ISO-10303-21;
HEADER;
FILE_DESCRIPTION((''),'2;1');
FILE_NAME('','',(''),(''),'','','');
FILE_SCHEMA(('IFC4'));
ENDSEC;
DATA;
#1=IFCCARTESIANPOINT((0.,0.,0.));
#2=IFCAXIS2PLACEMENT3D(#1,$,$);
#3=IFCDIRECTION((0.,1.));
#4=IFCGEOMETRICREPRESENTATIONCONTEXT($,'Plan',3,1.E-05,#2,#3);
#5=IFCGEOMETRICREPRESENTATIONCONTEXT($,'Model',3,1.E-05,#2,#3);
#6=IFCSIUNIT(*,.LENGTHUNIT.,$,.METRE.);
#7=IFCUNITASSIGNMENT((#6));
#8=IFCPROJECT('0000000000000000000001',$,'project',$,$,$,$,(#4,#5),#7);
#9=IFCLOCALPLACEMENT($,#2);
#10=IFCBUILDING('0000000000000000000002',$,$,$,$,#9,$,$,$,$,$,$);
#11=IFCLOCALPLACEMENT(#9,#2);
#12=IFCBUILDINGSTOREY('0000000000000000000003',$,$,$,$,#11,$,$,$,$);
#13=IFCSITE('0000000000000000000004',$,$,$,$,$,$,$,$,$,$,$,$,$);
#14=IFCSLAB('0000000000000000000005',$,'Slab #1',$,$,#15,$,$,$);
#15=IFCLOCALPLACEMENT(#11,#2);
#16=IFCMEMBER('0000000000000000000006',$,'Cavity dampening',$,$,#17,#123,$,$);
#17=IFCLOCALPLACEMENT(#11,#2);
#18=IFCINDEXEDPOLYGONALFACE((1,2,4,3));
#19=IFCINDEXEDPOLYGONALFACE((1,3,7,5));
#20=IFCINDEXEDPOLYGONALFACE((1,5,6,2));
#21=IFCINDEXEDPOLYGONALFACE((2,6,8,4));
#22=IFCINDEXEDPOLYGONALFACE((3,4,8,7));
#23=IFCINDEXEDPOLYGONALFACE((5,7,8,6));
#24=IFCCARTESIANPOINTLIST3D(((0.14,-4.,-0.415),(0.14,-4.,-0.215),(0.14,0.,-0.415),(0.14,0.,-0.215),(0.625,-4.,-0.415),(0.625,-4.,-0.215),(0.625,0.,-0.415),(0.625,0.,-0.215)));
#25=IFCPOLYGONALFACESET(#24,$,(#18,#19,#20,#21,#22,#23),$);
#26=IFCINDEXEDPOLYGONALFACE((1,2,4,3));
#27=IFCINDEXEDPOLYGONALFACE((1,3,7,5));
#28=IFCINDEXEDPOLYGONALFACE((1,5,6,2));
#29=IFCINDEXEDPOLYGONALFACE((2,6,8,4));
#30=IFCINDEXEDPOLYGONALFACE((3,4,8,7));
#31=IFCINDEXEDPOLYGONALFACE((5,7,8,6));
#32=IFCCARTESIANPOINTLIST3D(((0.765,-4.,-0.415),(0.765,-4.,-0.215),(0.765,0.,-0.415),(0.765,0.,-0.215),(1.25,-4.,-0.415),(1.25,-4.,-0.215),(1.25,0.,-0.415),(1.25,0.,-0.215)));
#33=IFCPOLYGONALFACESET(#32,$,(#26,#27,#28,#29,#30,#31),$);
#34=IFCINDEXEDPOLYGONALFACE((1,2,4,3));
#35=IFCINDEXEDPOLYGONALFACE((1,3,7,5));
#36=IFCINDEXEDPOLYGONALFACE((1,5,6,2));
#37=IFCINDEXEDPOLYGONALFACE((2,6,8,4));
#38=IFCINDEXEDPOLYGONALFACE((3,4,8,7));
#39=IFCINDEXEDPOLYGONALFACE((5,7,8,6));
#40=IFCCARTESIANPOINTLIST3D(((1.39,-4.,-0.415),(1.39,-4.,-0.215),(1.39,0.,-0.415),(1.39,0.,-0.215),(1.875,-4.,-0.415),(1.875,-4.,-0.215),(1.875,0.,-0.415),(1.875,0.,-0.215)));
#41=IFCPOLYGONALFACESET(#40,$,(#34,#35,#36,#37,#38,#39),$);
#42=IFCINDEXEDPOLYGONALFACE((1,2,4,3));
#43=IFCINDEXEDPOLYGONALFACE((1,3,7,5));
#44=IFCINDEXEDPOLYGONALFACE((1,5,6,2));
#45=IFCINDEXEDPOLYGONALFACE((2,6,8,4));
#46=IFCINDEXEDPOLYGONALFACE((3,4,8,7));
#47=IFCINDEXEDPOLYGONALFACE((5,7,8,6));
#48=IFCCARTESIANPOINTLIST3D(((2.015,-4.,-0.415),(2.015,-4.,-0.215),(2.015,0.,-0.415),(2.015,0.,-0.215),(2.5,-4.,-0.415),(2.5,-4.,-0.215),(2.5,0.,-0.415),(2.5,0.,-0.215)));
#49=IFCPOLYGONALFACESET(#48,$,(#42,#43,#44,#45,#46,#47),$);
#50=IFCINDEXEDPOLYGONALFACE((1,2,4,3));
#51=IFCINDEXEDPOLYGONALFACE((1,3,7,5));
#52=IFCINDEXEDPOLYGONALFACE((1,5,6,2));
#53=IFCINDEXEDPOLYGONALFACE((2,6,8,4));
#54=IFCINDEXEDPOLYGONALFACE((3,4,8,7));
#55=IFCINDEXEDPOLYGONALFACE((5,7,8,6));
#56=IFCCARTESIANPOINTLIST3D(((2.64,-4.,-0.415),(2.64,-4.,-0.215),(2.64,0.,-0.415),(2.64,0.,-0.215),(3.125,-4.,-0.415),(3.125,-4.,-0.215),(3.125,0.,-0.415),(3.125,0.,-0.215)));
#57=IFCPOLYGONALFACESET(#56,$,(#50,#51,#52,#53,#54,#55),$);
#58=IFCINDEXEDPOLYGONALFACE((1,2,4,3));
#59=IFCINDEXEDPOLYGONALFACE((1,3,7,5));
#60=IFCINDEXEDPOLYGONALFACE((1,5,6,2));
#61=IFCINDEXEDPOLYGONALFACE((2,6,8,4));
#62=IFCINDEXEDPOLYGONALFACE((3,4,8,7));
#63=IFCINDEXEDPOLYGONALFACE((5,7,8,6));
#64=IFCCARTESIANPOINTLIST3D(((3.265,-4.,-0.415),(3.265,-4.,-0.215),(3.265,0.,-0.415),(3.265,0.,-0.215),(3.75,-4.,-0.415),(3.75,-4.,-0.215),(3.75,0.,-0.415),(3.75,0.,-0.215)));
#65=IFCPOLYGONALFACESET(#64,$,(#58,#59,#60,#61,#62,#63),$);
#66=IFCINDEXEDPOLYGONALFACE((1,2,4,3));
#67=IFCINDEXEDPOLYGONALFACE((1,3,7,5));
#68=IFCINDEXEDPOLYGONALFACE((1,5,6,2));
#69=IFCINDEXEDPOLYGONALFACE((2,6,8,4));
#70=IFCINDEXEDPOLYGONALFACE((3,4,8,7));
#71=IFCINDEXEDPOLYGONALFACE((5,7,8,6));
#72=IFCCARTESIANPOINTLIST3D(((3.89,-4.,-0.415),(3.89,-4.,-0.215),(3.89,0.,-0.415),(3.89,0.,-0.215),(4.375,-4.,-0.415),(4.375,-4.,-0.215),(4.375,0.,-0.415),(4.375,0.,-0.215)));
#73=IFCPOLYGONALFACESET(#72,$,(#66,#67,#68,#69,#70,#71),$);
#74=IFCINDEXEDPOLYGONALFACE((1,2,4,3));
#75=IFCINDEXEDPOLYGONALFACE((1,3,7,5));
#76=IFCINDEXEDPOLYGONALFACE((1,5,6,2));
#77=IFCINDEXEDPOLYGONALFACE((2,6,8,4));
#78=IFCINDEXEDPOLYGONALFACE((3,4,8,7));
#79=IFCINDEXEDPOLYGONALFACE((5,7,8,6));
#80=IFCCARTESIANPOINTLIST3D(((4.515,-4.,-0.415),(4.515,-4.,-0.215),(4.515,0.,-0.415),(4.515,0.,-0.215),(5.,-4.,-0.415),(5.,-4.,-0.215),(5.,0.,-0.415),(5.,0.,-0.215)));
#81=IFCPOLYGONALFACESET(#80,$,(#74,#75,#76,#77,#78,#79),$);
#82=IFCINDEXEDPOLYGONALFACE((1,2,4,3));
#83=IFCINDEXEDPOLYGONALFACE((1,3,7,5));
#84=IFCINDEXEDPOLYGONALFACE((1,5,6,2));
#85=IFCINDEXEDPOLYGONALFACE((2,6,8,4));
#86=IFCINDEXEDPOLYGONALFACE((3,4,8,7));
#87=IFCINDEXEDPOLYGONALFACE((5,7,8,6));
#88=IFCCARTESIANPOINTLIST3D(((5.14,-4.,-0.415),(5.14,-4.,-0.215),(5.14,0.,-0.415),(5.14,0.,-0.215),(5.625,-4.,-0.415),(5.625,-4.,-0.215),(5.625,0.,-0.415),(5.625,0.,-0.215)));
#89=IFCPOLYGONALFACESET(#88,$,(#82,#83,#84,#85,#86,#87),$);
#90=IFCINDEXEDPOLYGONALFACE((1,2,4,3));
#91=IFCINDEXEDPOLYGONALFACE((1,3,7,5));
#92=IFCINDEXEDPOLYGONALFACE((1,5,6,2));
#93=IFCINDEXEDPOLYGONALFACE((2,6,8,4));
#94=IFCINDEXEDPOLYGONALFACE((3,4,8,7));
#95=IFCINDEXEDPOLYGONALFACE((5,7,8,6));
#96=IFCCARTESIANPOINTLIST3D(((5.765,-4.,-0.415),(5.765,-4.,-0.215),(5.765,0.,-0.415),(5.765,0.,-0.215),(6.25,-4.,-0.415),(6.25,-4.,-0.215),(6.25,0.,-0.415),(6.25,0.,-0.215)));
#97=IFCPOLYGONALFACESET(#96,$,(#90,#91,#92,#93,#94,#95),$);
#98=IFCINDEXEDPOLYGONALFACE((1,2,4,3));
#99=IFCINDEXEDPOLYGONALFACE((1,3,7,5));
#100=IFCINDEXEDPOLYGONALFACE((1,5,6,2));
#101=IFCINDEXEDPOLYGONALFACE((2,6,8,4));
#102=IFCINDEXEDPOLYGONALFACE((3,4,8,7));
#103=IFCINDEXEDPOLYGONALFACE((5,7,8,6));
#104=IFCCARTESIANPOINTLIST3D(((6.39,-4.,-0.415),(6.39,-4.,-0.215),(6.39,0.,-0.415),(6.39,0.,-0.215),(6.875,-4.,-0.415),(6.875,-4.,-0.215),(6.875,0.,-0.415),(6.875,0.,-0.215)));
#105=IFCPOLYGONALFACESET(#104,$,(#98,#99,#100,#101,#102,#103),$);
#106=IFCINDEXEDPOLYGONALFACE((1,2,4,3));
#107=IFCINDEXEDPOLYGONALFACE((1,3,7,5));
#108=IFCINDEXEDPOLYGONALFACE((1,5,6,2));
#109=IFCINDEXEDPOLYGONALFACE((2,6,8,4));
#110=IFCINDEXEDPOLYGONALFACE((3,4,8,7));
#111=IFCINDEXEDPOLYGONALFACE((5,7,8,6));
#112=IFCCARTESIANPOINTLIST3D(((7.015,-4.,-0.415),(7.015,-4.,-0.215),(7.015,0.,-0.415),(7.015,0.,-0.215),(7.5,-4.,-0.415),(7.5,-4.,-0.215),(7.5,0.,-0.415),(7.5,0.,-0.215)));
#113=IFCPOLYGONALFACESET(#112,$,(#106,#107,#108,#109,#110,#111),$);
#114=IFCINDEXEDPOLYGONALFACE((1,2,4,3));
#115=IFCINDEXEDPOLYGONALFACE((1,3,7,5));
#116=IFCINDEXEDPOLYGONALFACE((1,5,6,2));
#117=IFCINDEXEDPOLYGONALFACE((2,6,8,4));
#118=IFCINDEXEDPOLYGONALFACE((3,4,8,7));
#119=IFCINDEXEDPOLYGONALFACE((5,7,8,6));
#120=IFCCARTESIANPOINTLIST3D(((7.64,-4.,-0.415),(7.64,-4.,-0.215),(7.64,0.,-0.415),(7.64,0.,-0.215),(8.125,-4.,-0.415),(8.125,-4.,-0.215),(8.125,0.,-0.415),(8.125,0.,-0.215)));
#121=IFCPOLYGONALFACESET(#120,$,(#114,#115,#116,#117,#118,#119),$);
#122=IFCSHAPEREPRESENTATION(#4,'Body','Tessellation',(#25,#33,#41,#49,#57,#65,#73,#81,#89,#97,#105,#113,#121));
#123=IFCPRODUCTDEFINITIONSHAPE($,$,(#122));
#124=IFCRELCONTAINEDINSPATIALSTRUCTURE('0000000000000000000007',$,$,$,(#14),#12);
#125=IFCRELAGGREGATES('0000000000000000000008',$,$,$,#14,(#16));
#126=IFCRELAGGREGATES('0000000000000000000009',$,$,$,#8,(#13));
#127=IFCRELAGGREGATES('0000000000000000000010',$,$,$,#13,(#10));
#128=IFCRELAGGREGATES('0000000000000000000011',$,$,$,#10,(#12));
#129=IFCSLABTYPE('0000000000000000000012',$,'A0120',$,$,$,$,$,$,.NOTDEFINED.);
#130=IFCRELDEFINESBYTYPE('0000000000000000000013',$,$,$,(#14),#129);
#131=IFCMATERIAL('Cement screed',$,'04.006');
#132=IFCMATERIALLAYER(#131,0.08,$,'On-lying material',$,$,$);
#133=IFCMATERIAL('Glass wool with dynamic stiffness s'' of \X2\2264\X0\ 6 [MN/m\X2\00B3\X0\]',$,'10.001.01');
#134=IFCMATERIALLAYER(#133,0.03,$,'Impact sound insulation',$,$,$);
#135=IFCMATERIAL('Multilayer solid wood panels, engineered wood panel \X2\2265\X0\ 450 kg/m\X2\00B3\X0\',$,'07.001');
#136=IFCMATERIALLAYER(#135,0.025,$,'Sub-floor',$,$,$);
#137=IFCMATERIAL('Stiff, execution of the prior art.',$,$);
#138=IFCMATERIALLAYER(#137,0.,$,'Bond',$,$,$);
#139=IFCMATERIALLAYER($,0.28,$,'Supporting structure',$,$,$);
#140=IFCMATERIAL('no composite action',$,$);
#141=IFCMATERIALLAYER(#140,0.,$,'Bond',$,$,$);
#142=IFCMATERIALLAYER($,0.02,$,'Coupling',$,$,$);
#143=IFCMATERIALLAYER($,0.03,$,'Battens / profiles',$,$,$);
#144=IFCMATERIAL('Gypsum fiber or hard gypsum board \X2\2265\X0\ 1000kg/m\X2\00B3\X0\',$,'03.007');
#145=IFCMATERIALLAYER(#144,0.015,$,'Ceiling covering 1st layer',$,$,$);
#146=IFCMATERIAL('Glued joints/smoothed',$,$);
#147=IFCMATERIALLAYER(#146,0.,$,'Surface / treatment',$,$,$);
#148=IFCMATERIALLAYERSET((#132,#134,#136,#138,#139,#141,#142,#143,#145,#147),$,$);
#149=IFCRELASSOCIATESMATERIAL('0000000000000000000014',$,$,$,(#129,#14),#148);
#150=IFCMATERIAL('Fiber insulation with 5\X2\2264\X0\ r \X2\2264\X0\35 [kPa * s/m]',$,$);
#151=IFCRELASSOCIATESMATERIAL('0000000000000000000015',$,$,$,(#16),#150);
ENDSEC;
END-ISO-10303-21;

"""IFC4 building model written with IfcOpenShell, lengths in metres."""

from ifc_helpers import new_model, si_unit, direction, frame, frame_2d, origin, place, context, project, spatial, rectangle, extrude, material, layer, layer_set, type_object, element, aggregate, save


model = new_model("IFC4")

# Units and contexts
plan_context = context("Plan", 3, precision=1e-05, world=origin(), true_north=direction((0.0, 1.0)))
model_context = context("Model", 3, precision=1e-05, world=origin(), true_north=direction((0.0, 1.0)))
ifc_project = project(units=[si_unit("LENGTHUNIT", "METRE")], contexts=[plan_context, model_context])

# Site, building, storey
site = spatial("IfcSite", under=ifc_project)
building_placement = place(None, origin())
building = spatial("IfcBuilding", under=site, at=building_placement)
storey_placement = place(building_placement, origin())
storey = spatial("IfcBuildingStorey", under=building, at=storey_placement)

# Slab, member
ifc_material_1 = material(Name="Cement screed", Category="04.006")
ifc_layer_1 = layer(ifc_material_1, 0.08, Name="On-lying material")
ifc_material_2 = material(Name="Glass wool with dynamic stiffness s' of ≤ 6 [MN/m³]", Category="10.001.01")
ifc_layer_2 = layer(ifc_material_2, 0.03, Name="Impact sound insulation")
ifc_material_3 = material(Name="Multilayer solid wood panels, engineered wood panel ≥ 450 kg/m³", Category="07.001")
ifc_layer_3 = layer(ifc_material_3, 0.025, Name="Sub-floor")
ifc_material_4 = material(Name="Stiff, execution of the prior art.")
ifc_layer_4 = layer(ifc_material_4, 0.0, Name="Bond")
ifc_layer_5 = layer(None, 0.28, Name="Supporting structure")
ifc_material_5 = material(Name="no composite action")
ifc_layer_6 = layer(ifc_material_5, 0.0, Name="Bond")
ifc_layer_7 = layer(None, 0.02, Name="Coupling")
ifc_layer_8 = layer(None, 0.03, Name="Battens / profiles")
ifc_material_6 = material(Name="Gypsum fiber or hard gypsum board ≥ 1000kg/m³", Category="03.007")
ifc_layer_9 = layer(ifc_material_6, 0.015, Name="Ceiling covering 1st layer")
ifc_material_7 = material(Name="Glued joints/smoothed")
ifc_layer_10 = layer(ifc_material_7, 0.0, Name="Surface / treatment")
ifc_layer_set = layer_set([ifc_layer_1, ifc_layer_2, ifc_layer_3, ifc_layer_4, ifc_layer_5, ifc_layer_6, ifc_layer_7, ifc_layer_8, ifc_layer_9, ifc_layer_10])
slab_type = type_object("IfcSlabType", Name="A0120", PredefinedType="NOTDEFINED", material=ifc_layer_set)
slab_placement = place(None, frame((0.0, 0.0, 0.0), z_axis=(0.0, 0.0, -1.0), x_axis=(1.0, 0.0, 0.0)))
slab = element("IfcSlab", 1, at=slab_placement, inside=storey, type_object=slab_type, material=ifc_layer_set, Name="Slab #1")
ifc_material_8 = material(Name="Fiber insulation with 5≤ r ≤35 [kPa * s/m]")
member_1_placement = place(slab_placement, origin())
member_1 = element("IfcMember", 2, at=member_1_placement, material=ifc_material_8, Name="Cavity dampening", context=plan_context, shape_type="SweptSolid", body=[
    extrude(rectangle(XDim=0.485, YDim=0.2, at=frame_2d((0.2425, 0.1), x_axis=(1.0, 0.0))), frame((0.14, 4.0, 0.215), z_axis=(0.0, -1.0, 0.0), x_axis=(1.0, 0.0, 0.0)), (0.0, 0.0, 1.0), 4.0),
    extrude(rectangle(XDim=0.485, YDim=0.2, at=frame_2d((0.2425, 0.1), x_axis=(1.0, 0.0))), frame((0.765, 4.0, 0.215), z_axis=(0.0, -1.0, 0.0), x_axis=(1.0, 0.0, 0.0)), (0.0, 0.0, 1.0), 4.0),
    extrude(rectangle(XDim=0.485, YDim=0.2, at=frame_2d((0.2425, 0.1), x_axis=(1.0, 0.0))), frame((1.39, 4.0, 0.215), z_axis=(0.0, -1.0, 0.0), x_axis=(1.0, 0.0, 0.0)), (0.0, 0.0, 1.0), 4.0),
    extrude(rectangle(XDim=0.485, YDim=0.2, at=frame_2d((0.2425, 0.1), x_axis=(1.0, 0.0))), frame((2.015, 4.0, 0.215), z_axis=(0.0, -1.0, 0.0), x_axis=(1.0, 0.0, 0.0)), (0.0, 0.0, 1.0), 4.0),
    extrude(rectangle(XDim=0.485, YDim=0.2, at=frame_2d((0.2425, 0.1), x_axis=(1.0, 0.0))), frame((2.64, 4.0, 0.215), z_axis=(0.0, -1.0, 0.0), x_axis=(1.0, 0.0, 0.0)), (0.0, 0.0, 1.0), 4.0),
    extrude(rectangle(XDim=0.485, YDim=0.2, at=frame_2d((0.2425, 0.1), x_axis=(1.0, 0.0))), frame((3.265, 4.0, 0.215), z_axis=(0.0, -1.0, 0.0), x_axis=(1.0, 0.0, 0.0)), (0.0, 0.0, 1.0), 4.0),
    extrude(rectangle(XDim=0.485, YDim=0.2, at=frame_2d((0.2425, 0.1), x_axis=(1.0, 0.0))), frame((3.89, 4.0, 0.215), z_axis=(0.0, -1.0, 0.0), x_axis=(1.0, 0.0, 0.0)), (0.0, 0.0, 1.0), 4.0),
    extrude(rectangle(XDim=0.485, YDim=0.2, at=frame_2d((0.2425, 0.1), x_axis=(1.0, 0.0))), frame((4.515, 4.0, 0.215), z_axis=(0.0, -1.0, 0.0), x_axis=(1.0, 0.0, 0.0)), (0.0, 0.0, 1.0), 4.0),
    extrude(rectangle(XDim=0.485, YDim=0.2, at=frame_2d((0.2425, 0.1), x_axis=(1.0, 0.0))), frame((5.14, 4.0, 0.215), z_axis=(0.0, -1.0, 0.0), x_axis=(1.0, 0.0, 0.0)), (0.0, 0.0, 1.0), 4.0),
    extrude(rectangle(XDim=0.485, YDim=0.2, at=frame_2d((0.2425, 0.1), x_axis=(1.0, 0.0))), frame((5.765, 4.0, 0.215), z_axis=(0.0, -1.0, 0.0), x_axis=(1.0, 0.0, 0.0)), (0.0, 0.0, 1.0), 4.0),
    extrude(rectangle(XDim=0.485, YDim=0.2, at=frame_2d((0.2425, 0.1), x_axis=(1.0, 0.0))), frame((6.39, 4.0, 0.215), z_axis=(0.0, -1.0, 0.0), x_axis=(1.0, 0.0, 0.0)), (0.0, 0.0, 1.0), 4.0),
    extrude(rectangle(XDim=0.485, YDim=0.2, at=frame_2d((0.2425, 0.1), x_axis=(1.0, 0.0))), frame((7.015, 4.0, 0.215), z_axis=(0.0, -1.0, 0.0), x_axis=(1.0, 0.0, 0.0)), (0.0, 0.0, 1.0), 4.0),
    extrude(rectangle(XDim=0.485, YDim=0.2, at=frame_2d((0.2425, 0.1), x_axis=(1.0, 0.0))), frame((7.64, 4.0, 0.215), z_axis=(0.0, -1.0, 0.0), x_axis=(1.0, 0.0, 0.0)), (0.0, 0.0, 1.0), 4.0),
])
aggregate(slab, [member_1])

save(model, "model.ifc")
